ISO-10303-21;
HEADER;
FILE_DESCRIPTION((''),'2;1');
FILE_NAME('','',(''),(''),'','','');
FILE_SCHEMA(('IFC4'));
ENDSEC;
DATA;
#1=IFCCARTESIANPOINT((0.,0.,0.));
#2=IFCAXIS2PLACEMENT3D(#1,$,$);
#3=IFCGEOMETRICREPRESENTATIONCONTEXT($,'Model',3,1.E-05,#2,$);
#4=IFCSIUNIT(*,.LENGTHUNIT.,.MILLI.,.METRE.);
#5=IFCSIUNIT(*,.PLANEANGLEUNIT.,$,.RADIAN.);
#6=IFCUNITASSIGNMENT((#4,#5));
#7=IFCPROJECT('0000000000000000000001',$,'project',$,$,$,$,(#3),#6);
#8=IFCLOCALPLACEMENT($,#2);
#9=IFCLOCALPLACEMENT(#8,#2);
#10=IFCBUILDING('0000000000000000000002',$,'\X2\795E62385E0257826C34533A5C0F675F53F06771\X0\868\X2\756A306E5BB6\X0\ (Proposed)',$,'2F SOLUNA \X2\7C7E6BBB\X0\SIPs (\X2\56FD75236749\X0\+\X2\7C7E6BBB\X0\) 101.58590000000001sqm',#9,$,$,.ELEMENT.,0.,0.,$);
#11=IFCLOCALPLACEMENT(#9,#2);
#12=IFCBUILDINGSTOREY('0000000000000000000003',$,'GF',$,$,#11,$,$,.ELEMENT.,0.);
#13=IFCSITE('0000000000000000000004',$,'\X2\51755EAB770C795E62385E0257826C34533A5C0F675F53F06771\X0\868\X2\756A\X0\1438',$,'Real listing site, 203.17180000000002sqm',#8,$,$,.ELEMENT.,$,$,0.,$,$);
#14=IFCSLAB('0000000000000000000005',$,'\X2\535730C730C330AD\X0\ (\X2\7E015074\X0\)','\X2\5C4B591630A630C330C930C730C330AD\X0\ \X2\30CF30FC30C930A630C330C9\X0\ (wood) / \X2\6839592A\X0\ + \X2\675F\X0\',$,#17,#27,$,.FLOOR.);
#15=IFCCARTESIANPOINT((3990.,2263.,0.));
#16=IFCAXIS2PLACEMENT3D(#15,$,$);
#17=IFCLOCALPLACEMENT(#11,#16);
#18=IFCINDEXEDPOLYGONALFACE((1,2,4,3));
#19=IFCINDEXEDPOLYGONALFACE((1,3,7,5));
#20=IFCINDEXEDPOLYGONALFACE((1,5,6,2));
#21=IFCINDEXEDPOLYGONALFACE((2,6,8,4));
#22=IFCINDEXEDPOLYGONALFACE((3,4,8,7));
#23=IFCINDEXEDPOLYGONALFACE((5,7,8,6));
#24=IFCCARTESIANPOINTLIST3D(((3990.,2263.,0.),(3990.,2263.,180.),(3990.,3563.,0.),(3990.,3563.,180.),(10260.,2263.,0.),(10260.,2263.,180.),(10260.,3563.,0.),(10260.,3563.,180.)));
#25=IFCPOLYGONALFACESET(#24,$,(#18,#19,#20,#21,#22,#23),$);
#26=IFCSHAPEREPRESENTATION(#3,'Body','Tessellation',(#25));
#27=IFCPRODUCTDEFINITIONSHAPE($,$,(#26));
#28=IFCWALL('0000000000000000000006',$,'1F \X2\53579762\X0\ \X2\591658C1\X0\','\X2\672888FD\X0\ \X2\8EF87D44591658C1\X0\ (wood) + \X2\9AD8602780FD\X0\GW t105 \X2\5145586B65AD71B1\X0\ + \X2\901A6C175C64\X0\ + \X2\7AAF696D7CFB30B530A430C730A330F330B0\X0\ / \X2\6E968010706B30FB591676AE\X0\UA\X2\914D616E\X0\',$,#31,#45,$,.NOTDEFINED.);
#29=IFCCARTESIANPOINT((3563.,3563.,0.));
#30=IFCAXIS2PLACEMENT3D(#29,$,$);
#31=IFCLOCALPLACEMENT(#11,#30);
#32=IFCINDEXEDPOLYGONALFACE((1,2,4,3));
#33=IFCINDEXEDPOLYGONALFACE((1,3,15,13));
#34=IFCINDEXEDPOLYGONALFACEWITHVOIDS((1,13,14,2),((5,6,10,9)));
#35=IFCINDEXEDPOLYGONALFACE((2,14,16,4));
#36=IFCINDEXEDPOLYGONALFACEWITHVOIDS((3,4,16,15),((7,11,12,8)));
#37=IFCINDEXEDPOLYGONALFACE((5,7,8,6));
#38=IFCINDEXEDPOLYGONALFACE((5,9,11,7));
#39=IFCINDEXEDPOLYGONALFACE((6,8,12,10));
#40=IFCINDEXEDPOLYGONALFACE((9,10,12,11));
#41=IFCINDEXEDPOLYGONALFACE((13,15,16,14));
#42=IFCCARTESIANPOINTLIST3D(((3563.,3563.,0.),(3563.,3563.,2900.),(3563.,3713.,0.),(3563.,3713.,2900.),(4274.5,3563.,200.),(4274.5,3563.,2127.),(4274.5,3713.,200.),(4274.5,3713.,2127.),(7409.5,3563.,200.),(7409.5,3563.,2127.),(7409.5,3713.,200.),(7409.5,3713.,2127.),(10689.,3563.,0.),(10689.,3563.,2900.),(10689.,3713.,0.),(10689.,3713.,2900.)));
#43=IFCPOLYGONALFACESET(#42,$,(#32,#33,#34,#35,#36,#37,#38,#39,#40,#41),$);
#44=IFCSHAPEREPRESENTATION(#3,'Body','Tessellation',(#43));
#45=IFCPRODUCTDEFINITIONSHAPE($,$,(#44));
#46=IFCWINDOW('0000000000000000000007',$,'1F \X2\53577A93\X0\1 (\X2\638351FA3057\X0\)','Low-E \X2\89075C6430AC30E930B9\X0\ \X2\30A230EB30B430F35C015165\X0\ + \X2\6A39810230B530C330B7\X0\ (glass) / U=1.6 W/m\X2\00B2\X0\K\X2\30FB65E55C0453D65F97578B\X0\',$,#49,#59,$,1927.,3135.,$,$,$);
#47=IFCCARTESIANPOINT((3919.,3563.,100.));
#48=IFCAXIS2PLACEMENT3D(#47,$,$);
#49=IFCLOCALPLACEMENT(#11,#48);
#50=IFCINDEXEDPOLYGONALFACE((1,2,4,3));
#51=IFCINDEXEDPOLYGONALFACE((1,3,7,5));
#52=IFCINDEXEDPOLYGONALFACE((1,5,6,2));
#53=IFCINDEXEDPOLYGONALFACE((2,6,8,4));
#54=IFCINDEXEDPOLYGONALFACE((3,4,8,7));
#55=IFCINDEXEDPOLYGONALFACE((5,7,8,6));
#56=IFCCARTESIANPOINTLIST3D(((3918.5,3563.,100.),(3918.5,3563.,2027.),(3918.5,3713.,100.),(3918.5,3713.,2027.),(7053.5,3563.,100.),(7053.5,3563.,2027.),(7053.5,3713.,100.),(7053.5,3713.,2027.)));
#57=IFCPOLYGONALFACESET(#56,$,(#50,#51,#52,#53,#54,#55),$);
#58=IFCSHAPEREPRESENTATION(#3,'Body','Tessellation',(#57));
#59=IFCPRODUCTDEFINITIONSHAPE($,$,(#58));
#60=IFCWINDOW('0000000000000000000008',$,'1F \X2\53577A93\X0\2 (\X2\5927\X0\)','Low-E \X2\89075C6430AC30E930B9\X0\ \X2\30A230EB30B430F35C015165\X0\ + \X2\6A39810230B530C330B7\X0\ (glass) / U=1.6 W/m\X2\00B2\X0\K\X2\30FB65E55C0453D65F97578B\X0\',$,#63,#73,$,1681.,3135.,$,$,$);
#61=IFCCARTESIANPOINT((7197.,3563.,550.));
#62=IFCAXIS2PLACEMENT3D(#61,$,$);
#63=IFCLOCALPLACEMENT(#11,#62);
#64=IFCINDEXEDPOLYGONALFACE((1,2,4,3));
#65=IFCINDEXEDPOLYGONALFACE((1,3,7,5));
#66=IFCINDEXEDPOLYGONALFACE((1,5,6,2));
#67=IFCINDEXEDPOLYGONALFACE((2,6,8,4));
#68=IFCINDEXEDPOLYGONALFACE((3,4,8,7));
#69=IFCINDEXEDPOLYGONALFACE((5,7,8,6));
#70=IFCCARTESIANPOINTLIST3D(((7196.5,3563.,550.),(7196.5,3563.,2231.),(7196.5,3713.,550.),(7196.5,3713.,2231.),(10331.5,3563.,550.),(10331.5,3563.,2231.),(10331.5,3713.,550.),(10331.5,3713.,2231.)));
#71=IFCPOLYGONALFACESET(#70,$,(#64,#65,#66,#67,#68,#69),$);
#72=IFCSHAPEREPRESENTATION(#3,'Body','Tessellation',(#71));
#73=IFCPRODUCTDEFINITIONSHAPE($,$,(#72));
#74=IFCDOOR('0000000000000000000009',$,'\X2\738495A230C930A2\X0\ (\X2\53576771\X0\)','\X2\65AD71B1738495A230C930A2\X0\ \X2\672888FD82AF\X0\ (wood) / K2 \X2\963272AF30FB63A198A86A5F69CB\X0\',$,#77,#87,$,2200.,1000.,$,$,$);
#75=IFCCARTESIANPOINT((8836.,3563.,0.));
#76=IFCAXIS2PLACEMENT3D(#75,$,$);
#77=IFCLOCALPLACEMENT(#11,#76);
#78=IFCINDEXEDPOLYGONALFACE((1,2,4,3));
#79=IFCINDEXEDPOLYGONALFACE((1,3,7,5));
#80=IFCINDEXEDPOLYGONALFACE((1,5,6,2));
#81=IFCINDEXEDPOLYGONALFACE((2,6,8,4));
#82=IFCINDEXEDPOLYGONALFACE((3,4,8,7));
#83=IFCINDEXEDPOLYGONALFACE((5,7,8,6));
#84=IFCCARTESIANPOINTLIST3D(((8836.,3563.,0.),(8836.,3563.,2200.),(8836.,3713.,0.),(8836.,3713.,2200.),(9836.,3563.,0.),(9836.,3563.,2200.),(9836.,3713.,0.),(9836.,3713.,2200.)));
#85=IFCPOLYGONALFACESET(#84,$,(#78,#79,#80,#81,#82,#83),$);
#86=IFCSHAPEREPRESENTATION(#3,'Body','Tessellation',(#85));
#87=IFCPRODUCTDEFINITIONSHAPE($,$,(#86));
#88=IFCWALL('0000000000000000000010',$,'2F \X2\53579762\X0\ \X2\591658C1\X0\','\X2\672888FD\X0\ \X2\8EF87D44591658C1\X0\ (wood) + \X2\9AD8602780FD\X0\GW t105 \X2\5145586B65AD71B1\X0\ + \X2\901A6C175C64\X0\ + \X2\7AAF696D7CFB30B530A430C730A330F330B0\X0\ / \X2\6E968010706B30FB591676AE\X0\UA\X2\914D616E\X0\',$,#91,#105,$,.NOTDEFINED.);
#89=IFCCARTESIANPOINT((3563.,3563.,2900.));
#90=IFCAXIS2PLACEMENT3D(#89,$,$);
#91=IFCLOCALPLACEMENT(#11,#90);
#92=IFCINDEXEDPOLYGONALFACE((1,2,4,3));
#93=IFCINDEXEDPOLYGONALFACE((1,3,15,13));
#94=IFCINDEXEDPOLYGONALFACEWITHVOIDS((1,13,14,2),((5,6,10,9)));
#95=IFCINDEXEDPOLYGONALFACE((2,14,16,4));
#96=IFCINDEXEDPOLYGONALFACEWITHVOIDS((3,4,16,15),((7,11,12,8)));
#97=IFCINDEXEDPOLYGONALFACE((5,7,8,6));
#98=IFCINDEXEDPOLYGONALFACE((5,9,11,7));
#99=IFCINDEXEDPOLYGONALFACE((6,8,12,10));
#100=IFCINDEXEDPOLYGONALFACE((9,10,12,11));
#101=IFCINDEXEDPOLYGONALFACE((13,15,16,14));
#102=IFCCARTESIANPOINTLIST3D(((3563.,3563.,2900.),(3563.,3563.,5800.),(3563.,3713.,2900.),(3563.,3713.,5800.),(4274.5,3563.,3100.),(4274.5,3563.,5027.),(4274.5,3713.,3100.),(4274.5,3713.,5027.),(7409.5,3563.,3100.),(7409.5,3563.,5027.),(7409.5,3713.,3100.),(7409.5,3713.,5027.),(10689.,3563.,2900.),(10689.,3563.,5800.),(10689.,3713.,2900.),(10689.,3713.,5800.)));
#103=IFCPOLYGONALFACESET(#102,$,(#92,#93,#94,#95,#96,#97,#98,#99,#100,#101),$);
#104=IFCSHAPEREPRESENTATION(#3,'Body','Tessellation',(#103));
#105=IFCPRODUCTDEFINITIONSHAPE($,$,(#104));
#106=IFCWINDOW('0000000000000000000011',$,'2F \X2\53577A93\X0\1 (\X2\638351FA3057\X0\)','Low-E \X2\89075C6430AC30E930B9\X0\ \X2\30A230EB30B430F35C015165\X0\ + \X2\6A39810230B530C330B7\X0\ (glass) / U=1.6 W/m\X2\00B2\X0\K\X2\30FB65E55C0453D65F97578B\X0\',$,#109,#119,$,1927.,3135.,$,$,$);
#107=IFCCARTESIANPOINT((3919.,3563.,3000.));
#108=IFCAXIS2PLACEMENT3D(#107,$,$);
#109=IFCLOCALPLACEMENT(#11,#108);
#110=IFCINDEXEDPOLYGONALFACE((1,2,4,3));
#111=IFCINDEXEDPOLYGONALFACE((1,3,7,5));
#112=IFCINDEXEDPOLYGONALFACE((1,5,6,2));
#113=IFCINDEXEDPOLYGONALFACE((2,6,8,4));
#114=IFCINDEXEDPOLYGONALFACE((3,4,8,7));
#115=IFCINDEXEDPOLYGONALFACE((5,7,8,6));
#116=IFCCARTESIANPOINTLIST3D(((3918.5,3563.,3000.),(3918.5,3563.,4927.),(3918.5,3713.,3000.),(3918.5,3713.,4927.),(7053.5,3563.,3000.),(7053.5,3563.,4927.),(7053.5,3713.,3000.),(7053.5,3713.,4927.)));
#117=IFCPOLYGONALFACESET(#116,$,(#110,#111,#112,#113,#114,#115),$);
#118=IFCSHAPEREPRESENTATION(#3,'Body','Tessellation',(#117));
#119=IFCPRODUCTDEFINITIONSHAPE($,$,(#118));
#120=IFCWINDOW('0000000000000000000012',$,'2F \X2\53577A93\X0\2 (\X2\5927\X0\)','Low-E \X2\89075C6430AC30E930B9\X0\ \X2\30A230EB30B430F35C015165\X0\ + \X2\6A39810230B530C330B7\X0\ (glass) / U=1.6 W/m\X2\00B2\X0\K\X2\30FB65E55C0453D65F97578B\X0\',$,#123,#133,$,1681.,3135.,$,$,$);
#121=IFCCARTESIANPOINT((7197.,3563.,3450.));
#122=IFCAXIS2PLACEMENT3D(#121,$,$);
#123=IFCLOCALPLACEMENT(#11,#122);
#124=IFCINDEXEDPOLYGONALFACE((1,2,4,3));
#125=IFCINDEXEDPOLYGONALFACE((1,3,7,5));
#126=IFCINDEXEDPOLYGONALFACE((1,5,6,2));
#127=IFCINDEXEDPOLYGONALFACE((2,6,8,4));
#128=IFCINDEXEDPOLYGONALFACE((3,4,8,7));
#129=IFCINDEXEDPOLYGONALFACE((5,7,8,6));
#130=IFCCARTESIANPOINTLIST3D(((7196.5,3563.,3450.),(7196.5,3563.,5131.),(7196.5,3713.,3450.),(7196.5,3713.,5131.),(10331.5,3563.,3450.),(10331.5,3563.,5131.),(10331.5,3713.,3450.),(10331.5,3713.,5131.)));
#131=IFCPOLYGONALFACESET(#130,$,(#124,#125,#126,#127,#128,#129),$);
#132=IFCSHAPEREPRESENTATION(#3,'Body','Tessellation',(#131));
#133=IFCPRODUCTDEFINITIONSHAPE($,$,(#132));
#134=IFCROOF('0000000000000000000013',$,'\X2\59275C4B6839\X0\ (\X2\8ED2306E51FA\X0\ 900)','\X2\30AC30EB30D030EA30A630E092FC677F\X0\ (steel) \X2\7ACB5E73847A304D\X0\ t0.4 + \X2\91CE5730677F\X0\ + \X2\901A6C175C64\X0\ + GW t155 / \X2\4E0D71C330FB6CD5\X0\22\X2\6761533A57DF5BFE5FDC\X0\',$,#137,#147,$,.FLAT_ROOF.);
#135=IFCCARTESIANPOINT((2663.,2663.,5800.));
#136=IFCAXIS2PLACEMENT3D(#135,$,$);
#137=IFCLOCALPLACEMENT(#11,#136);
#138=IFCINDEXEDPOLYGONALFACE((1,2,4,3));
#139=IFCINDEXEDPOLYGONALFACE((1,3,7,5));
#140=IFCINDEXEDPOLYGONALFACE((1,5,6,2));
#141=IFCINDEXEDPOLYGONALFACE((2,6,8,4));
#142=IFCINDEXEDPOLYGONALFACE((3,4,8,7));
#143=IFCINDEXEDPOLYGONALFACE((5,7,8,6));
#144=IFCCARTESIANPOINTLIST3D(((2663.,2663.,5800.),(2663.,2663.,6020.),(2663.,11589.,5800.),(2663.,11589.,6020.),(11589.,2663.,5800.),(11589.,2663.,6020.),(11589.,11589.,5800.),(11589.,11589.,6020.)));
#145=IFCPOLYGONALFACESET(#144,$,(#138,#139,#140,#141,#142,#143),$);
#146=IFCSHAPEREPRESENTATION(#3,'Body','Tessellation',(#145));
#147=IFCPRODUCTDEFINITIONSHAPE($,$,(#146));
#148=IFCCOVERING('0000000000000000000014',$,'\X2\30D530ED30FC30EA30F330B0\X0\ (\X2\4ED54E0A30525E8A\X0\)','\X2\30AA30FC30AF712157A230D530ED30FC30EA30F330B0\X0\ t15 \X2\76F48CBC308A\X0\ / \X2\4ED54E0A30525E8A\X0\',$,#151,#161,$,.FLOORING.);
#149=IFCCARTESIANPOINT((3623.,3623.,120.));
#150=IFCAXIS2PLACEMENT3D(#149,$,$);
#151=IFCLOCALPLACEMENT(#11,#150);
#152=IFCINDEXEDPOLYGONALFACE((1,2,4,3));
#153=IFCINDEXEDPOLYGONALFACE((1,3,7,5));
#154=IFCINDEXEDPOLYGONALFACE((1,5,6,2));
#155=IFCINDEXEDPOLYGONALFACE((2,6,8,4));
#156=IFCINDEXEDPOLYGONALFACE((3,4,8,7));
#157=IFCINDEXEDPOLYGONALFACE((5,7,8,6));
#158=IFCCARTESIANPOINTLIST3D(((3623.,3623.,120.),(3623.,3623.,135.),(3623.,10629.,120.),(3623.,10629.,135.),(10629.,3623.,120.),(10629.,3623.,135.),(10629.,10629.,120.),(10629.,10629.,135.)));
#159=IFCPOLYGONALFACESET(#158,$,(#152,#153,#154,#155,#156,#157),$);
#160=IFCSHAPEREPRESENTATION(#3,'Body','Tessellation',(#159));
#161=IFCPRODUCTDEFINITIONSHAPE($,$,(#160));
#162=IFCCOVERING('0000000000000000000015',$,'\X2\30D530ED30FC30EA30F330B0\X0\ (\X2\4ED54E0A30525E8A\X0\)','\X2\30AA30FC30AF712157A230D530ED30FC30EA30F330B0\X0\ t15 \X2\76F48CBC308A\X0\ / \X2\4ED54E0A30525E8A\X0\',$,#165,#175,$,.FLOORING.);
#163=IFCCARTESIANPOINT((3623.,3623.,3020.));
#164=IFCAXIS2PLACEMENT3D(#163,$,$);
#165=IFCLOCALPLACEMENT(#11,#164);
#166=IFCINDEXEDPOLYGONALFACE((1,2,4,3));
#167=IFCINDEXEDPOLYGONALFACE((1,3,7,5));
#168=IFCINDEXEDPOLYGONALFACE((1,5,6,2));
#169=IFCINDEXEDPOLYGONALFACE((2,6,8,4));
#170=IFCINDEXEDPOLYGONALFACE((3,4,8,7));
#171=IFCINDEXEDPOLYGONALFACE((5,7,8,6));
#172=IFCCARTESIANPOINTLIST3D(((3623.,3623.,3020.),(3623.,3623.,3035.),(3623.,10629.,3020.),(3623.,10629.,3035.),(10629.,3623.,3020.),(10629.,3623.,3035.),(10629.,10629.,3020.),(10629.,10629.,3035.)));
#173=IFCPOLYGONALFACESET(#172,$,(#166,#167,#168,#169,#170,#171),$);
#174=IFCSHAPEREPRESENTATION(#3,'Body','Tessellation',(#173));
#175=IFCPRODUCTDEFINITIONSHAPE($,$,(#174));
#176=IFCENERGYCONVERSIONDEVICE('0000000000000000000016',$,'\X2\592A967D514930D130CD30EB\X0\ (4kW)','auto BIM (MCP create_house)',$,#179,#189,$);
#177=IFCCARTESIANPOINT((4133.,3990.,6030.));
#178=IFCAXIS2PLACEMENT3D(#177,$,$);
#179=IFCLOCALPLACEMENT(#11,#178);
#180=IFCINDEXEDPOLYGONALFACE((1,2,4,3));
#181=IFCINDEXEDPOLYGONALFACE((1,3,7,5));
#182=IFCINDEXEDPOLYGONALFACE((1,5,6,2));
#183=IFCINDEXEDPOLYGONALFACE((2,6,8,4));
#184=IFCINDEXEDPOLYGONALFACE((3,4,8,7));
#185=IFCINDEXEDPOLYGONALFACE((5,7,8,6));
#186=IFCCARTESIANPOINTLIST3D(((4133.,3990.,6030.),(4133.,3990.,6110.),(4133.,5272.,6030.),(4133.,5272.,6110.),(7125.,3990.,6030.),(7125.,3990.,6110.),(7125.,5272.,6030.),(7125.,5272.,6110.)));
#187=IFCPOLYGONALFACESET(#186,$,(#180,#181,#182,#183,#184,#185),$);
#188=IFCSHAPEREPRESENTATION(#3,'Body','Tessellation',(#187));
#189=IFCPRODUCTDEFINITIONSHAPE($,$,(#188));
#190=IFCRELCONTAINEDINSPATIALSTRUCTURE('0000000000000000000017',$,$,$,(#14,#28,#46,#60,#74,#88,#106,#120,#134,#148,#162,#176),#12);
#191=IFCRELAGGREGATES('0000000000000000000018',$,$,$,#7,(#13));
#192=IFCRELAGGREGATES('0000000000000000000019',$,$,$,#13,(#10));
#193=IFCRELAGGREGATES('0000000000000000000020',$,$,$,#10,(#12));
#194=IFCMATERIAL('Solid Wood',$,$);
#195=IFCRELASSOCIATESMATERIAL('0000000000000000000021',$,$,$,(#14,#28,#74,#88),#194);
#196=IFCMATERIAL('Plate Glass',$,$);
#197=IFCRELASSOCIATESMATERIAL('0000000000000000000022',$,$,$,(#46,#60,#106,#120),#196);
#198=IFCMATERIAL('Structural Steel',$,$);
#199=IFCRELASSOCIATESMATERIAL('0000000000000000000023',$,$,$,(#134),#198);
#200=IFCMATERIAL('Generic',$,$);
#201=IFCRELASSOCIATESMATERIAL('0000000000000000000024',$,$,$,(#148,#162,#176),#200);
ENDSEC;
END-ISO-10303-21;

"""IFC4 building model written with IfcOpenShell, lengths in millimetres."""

from ifc_helpers import new_model, si_unit, frame, frame_2d, origin, place, context, project, spatial, rectangle, extrude, material, element, fill, save


model = new_model("IFC4")

# Units and contexts
model_context = context("Model", 3, precision=1e-05, world=origin())
ifc_project = project(units=[si_unit("LENGTHUNIT", "METRE", prefix="MILLI"), si_unit("PLANEANGLEUNIT", "RADIAN")], contexts=[model_context])

# Site, building, storey
site_placement = place(None, origin())
site = spatial("IfcSite", under=ifc_project, at=site_placement, Name="兵庫県神戸市垂水区小束台東868番1438", ObjectType="Real listing site, 203.17180000000002sqm", CompositionType="ELEMENT", RefElevation=0.0)
building_placement = place(site_placement, origin())
building = spatial("IfcBuilding", under=site, at=building_placement, Name="神戸市垂水区小束台東868番の家 (Proposed)", ObjectType="2F SOLUNA 籾殻SIPs (国産杉+籾殻) 101.58590000000001sqm", CompositionType="ELEMENT", ElevationOfRefHeight=0.0, ElevationOfTerrain=0.0)
storey_placement = place(building_placement, origin())
storey = spatial("IfcBuildingStorey", under=building, at=storey_placement, Name="GF", CompositionType="ELEMENT", Elevation=0.0)

# Slab
ifc_material_1 = material(Name="Solid Wood")
slab_1_placement = place(storey_placement, frame((3990.0, 2263.0, 0.0)))
element("IfcSlab", 1, at=slab_1_placement, inside=storey, material=ifc_material_1, Name="南デッキ (縁側)", Description="屋外ウッドデッキ ハードウッド (wood) / 根太 + 束", PredefinedType="FLOOR", context=model_context, shape_type="SweptSolid", body=[
    extrude(rectangle(XDim=6270.0, YDim=1300.0, at=frame_2d((3135.0, 650.0))), frame((3990.0, 2263.0, 0.0)), (0.0, 0.0, 1.0), 180.0),
])

# Wall, openings, windows, door
wall_1_placement = place(storey_placement, frame((3563.0, 3563.0, 0.0)))
wall_1 = element("IfcWall", 2, at=wall_1_placement, inside=storey, material=ifc_material_1, Name="1F 南面 外壁", Description="木製 軸組外壁 (wood) + 高性能GW t105 充填断熱 + 通気層 + 窯業系サイディング / 準耐火・外皮UA配慮", PredefinedType="NOTDEFINED", context=model_context, shape_type="SweptSolid", body=[
    extrude(rectangle(XDim=7126.0, YDim=150.0, at=frame_2d((3563.0, 75.0))), frame((3563.0, 3563.0, 0.0)), (0.0, 0.0, 1.0), 2900.0),
])
opening_1_placement = place(storey_placement, frame((3919.0, 3563.0, 100.0)))
opening_1 = element("IfcOpeningElement", 3, at=opening_1_placement, cuts=wall_1, PredefinedType="NOTDEFINED", context=model_context, shape_type="SweptSolid", body=[
    extrude(rectangle(XDim=3135.0, YDim=150.0, at=frame_2d((1567.0, 75.0))), frame((3919.0, 3563.0, 100.0)), (0.0, 0.0, 1.0), 1927.0),
])
opening_2_placement = place(storey_placement, frame((7197.0, 3563.0, 550.0)))
opening_2 = element("IfcOpeningElement", 4, at=opening_2_placement, cuts=wall_1, PredefinedType="NOTDEFINED", context=model_context, shape_type="SweptSolid", body=[
    extrude(rectangle(XDim=3135.0, YDim=150.0, at=frame_2d((1567.0, 75.0))), frame((7197.0, 3563.0, 550.0)), (0.0, 0.0, 1.0), 1681.0),
])
opening_3_placement = place(storey_placement, frame((8836.0, 3563.0, 0.0)))
opening_3 = element("IfcOpeningElement", 5, at=opening_3_placement, cuts=wall_1, PredefinedType="NOTDEFINED", context=model_context, shape_type="SweptSolid", body=[
    extrude(rectangle(XDim=1000.0, YDim=150.0, at=frame_2d((500.0, 75.0))), frame((8836.0, 3563.0, 0.0)), (0.0, 0.0, 1.0), 2200.0),
])
ifc_material_2 = material(Name="Plate Glass")
window_1_placement = place(storey_placement, frame((3919.0, 3563.0, 100.0)))
window_1 = element("IfcWindow", 6, at=window_1_placement, inside=storey, material=ifc_material_2, Name="1F 南窓1 (掃出し)", Description="Low-E 複層ガラス アルゴン封入 + 樹脂サッシ (glass) / U=1.6 W/m²K・日射取得型", OverallHeight=1927.0, OverallWidth=3135.0, context=model_context, shape_type="SweptSolid", body=[
    extrude(rectangle(XDim=3135.0, YDim=150.0, at=frame_2d((1567.0, 75.0))), frame((3919.0, 3563.0, 100.0)), (0.0, 0.0, 1.0), 1927.0),
])
fill(opening_1, window_1)
window_2_placement = place(storey_placement, frame((7197.0, 3563.0, 550.0)))
window_2 = element("IfcWindow", 7, at=window_2_placement, inside=storey, material=ifc_material_2, Name="1F 南窓2 (大)", Description="Low-E 複層ガラス アルゴン封入 + 樹脂サッシ (glass) / U=1.6 W/m²K・日射取得型", OverallHeight=1681.0, OverallWidth=3135.0, context=model_context, shape_type="SweptSolid", body=[
    extrude(rectangle(XDim=3135.0, YDim=150.0, at=frame_2d((1567.0, 75.0))), frame((7197.0, 3563.0, 550.0)), (0.0, 0.0, 1.0), 1681.0),
])
fill(opening_2, window_2)
door_placement = place(storey_placement, frame((8836.0, 3563.0, 0.0)))
door = element("IfcDoor", 8, at=door_placement, inside=storey, material=ifc_material_1, Name="玄関ドア (南東)", Description="断熱玄関ドア 木製芯 (wood) / K2 防犯・採風機構", OverallHeight=2200.0, OverallWidth=1000.0, context=model_context, shape_type="SweptSolid", body=[
    extrude(rectangle(XDim=1000.0, YDim=150.0, at=frame_2d((500.0, 75.0))), frame((8836.0, 3563.0, 0.0)), (0.0, 0.0, 1.0), 2200.0),
])
fill(opening_3, door)

# Wall, openings, windows
wall_2_placement = place(storey_placement, frame((3563.0, 3563.0, 2900.0)))
wall_2 = element("IfcWall", 9, at=wall_2_placement, inside=storey, material=ifc_material_1, Name="2F 南面 外壁", Description="木製 軸組外壁 (wood) + 高性能GW t105 充填断熱 + 通気層 + 窯業系サイディング / 準耐火・外皮UA配慮", PredefinedType="NOTDEFINED", context=model_context, shape_type="SweptSolid", body=[
    extrude(rectangle(XDim=7126.0, YDim=150.0, at=frame_2d((3563.0, 75.0))), frame((3563.0, 3563.0, 2900.0)), (0.0, 0.0, 1.0), 2900.0),
])
opening_4_placement = place(storey_placement, frame((3919.0, 3563.0, 3000.0)))
opening_4 = element("IfcOpeningElement", 10, at=opening_4_placement, cuts=wall_2, PredefinedType="NOTDEFINED", context=model_context, shape_type="SweptSolid", body=[
    extrude(rectangle(XDim=3135.0, YDim=150.0, at=frame_2d((1567.0, 75.0))), frame((3919.0, 3563.0, 3000.0)), (0.0, 0.0, 1.0), 1927.0),
])
opening_5_placement = place(storey_placement, frame((7197.0, 3563.0, 3450.0)))
opening_5 = element("IfcOpeningElement", 11, at=opening_5_placement, cuts=wall_2, PredefinedType="NOTDEFINED", context=model_context, shape_type="SweptSolid", body=[
    extrude(rectangle(XDim=3135.0, YDim=150.0, at=frame_2d((1567.0, 75.0))), frame((7197.0, 3563.0, 3450.0)), (0.0, 0.0, 1.0), 1681.0),
])
window_3_placement = place(storey_placement, frame((3919.0, 3563.0, 3000.0)))
window_3 = element("IfcWindow", 12, at=window_3_placement, inside=storey, material=ifc_material_2, Name="2F 南窓1 (掃出し)", Description="Low-E 複層ガラス アルゴン封入 + 樹脂サッシ (glass) / U=1.6 W/m²K・日射取得型", OverallHeight=1927.0, OverallWidth=3135.0, context=model_context, shape_type="SweptSolid", body=[
    extrude(rectangle(XDim=3135.0, YDim=150.0, at=frame_2d((1567.0, 75.0))), frame((3919.0, 3563.0, 3000.0)), (0.0, 0.0, 1.0), 1927.0),
])
fill(opening_4, window_3)
window_4_placement = place(storey_placement, frame((7197.0, 3563.0, 3450.0)))
window_4 = element("IfcWindow", 13, at=window_4_placement, inside=storey, material=ifc_material_2, Name="2F 南窓2 (大)", Description="Low-E 複層ガラス アルゴン封入 + 樹脂サッシ (glass) / U=1.6 W/m²K・日射取得型", OverallHeight=1681.0, OverallWidth=3135.0, context=model_context, shape_type="SweptSolid", body=[
    extrude(rectangle(XDim=3135.0, YDim=150.0, at=frame_2d((1567.0, 75.0))), frame((7197.0, 3563.0, 3450.0)), (0.0, 0.0, 1.0), 1681.0),
])
fill(opening_5, window_4)

# Roof
ifc_material_3 = material(Name="Structural Steel")
roof_placement = place(storey_placement, frame((2663.0, 2663.0, 5800.0)))
element("IfcRoof", 14, at=roof_placement, inside=storey, material=ifc_material_3, Name="大屋根 (軒の出 900)", Description="ガルバリウム鋼板 (steel) 立平葺き t0.4 + 野地板 + 通気層 + GW t155 / 不燃・法22条区域対応", PredefinedType="FLAT_ROOF", context=model_context, shape_type="SweptSolid", body=[
    extrude(rectangle(XDim=8926.0, YDim=8926.0, at=frame_2d((4463.0, 4463.0))), frame((2663.0, 2663.0, 5800.0)), (0.0, 0.0, 1.0), 220.0),
])

# Coverings
ifc_material_4 = material(Name="Generic")
covering_1_placement = place(storey_placement, frame((3623.0, 3623.0, 120.0)))
element("IfcCovering", 15, at=covering_1_placement, inside=storey, material=ifc_material_4, Name="フローリング (仕上げ床)", Description="オーク無垢フローリング t15 直貼り / 仕上げ床", PredefinedType="FLOORING", context=model_context, shape_type="SweptSolid", body=[
    extrude(rectangle(XDim=7006.0, YDim=7006.0, at=frame_2d((3503.0, 3503.0))), frame((3623.0, 3623.0, 120.0)), (0.0, 0.0, 1.0), 15.0),
])
covering_2_placement = place(storey_placement, frame((3623.0, 3623.0, 3020.0)))
element("IfcCovering", 16, at=covering_2_placement, inside=storey, material=ifc_material_4, Name="フローリング (仕上げ床)", Description="オーク無垢フローリング t15 直貼り / 仕上げ床", PredefinedType="FLOORING", context=model_context, shape_type="SweptSolid", body=[
    extrude(rectangle(XDim=7006.0, YDim=7006.0, at=frame_2d((3503.0, 3503.0))), frame((3623.0, 3623.0, 3020.0)), (0.0, 0.0, 1.0), 15.0),
])

# Energy conversion device
energy_conversion_device_placement = place(storey_placement, frame((4133.0, 3990.0, 6030.0)))
element("IfcEnergyConversionDevice", 17, at=energy_conversion_device_placement, inside=storey, material=ifc_material_4, Name="太陽光パネル (4kW)", Description="auto BIM (MCP create_house)", context=model_context, shape_type="SweptSolid", body=[
    extrude(rectangle(XDim=2992.0, YDim=1282.0, at=frame_2d((1496.0, 641.0))), frame((4133.0, 3990.0, 6030.0)), (0.0, 0.0, 1.0), 80.0),
])

save(model, "model.ifc")
